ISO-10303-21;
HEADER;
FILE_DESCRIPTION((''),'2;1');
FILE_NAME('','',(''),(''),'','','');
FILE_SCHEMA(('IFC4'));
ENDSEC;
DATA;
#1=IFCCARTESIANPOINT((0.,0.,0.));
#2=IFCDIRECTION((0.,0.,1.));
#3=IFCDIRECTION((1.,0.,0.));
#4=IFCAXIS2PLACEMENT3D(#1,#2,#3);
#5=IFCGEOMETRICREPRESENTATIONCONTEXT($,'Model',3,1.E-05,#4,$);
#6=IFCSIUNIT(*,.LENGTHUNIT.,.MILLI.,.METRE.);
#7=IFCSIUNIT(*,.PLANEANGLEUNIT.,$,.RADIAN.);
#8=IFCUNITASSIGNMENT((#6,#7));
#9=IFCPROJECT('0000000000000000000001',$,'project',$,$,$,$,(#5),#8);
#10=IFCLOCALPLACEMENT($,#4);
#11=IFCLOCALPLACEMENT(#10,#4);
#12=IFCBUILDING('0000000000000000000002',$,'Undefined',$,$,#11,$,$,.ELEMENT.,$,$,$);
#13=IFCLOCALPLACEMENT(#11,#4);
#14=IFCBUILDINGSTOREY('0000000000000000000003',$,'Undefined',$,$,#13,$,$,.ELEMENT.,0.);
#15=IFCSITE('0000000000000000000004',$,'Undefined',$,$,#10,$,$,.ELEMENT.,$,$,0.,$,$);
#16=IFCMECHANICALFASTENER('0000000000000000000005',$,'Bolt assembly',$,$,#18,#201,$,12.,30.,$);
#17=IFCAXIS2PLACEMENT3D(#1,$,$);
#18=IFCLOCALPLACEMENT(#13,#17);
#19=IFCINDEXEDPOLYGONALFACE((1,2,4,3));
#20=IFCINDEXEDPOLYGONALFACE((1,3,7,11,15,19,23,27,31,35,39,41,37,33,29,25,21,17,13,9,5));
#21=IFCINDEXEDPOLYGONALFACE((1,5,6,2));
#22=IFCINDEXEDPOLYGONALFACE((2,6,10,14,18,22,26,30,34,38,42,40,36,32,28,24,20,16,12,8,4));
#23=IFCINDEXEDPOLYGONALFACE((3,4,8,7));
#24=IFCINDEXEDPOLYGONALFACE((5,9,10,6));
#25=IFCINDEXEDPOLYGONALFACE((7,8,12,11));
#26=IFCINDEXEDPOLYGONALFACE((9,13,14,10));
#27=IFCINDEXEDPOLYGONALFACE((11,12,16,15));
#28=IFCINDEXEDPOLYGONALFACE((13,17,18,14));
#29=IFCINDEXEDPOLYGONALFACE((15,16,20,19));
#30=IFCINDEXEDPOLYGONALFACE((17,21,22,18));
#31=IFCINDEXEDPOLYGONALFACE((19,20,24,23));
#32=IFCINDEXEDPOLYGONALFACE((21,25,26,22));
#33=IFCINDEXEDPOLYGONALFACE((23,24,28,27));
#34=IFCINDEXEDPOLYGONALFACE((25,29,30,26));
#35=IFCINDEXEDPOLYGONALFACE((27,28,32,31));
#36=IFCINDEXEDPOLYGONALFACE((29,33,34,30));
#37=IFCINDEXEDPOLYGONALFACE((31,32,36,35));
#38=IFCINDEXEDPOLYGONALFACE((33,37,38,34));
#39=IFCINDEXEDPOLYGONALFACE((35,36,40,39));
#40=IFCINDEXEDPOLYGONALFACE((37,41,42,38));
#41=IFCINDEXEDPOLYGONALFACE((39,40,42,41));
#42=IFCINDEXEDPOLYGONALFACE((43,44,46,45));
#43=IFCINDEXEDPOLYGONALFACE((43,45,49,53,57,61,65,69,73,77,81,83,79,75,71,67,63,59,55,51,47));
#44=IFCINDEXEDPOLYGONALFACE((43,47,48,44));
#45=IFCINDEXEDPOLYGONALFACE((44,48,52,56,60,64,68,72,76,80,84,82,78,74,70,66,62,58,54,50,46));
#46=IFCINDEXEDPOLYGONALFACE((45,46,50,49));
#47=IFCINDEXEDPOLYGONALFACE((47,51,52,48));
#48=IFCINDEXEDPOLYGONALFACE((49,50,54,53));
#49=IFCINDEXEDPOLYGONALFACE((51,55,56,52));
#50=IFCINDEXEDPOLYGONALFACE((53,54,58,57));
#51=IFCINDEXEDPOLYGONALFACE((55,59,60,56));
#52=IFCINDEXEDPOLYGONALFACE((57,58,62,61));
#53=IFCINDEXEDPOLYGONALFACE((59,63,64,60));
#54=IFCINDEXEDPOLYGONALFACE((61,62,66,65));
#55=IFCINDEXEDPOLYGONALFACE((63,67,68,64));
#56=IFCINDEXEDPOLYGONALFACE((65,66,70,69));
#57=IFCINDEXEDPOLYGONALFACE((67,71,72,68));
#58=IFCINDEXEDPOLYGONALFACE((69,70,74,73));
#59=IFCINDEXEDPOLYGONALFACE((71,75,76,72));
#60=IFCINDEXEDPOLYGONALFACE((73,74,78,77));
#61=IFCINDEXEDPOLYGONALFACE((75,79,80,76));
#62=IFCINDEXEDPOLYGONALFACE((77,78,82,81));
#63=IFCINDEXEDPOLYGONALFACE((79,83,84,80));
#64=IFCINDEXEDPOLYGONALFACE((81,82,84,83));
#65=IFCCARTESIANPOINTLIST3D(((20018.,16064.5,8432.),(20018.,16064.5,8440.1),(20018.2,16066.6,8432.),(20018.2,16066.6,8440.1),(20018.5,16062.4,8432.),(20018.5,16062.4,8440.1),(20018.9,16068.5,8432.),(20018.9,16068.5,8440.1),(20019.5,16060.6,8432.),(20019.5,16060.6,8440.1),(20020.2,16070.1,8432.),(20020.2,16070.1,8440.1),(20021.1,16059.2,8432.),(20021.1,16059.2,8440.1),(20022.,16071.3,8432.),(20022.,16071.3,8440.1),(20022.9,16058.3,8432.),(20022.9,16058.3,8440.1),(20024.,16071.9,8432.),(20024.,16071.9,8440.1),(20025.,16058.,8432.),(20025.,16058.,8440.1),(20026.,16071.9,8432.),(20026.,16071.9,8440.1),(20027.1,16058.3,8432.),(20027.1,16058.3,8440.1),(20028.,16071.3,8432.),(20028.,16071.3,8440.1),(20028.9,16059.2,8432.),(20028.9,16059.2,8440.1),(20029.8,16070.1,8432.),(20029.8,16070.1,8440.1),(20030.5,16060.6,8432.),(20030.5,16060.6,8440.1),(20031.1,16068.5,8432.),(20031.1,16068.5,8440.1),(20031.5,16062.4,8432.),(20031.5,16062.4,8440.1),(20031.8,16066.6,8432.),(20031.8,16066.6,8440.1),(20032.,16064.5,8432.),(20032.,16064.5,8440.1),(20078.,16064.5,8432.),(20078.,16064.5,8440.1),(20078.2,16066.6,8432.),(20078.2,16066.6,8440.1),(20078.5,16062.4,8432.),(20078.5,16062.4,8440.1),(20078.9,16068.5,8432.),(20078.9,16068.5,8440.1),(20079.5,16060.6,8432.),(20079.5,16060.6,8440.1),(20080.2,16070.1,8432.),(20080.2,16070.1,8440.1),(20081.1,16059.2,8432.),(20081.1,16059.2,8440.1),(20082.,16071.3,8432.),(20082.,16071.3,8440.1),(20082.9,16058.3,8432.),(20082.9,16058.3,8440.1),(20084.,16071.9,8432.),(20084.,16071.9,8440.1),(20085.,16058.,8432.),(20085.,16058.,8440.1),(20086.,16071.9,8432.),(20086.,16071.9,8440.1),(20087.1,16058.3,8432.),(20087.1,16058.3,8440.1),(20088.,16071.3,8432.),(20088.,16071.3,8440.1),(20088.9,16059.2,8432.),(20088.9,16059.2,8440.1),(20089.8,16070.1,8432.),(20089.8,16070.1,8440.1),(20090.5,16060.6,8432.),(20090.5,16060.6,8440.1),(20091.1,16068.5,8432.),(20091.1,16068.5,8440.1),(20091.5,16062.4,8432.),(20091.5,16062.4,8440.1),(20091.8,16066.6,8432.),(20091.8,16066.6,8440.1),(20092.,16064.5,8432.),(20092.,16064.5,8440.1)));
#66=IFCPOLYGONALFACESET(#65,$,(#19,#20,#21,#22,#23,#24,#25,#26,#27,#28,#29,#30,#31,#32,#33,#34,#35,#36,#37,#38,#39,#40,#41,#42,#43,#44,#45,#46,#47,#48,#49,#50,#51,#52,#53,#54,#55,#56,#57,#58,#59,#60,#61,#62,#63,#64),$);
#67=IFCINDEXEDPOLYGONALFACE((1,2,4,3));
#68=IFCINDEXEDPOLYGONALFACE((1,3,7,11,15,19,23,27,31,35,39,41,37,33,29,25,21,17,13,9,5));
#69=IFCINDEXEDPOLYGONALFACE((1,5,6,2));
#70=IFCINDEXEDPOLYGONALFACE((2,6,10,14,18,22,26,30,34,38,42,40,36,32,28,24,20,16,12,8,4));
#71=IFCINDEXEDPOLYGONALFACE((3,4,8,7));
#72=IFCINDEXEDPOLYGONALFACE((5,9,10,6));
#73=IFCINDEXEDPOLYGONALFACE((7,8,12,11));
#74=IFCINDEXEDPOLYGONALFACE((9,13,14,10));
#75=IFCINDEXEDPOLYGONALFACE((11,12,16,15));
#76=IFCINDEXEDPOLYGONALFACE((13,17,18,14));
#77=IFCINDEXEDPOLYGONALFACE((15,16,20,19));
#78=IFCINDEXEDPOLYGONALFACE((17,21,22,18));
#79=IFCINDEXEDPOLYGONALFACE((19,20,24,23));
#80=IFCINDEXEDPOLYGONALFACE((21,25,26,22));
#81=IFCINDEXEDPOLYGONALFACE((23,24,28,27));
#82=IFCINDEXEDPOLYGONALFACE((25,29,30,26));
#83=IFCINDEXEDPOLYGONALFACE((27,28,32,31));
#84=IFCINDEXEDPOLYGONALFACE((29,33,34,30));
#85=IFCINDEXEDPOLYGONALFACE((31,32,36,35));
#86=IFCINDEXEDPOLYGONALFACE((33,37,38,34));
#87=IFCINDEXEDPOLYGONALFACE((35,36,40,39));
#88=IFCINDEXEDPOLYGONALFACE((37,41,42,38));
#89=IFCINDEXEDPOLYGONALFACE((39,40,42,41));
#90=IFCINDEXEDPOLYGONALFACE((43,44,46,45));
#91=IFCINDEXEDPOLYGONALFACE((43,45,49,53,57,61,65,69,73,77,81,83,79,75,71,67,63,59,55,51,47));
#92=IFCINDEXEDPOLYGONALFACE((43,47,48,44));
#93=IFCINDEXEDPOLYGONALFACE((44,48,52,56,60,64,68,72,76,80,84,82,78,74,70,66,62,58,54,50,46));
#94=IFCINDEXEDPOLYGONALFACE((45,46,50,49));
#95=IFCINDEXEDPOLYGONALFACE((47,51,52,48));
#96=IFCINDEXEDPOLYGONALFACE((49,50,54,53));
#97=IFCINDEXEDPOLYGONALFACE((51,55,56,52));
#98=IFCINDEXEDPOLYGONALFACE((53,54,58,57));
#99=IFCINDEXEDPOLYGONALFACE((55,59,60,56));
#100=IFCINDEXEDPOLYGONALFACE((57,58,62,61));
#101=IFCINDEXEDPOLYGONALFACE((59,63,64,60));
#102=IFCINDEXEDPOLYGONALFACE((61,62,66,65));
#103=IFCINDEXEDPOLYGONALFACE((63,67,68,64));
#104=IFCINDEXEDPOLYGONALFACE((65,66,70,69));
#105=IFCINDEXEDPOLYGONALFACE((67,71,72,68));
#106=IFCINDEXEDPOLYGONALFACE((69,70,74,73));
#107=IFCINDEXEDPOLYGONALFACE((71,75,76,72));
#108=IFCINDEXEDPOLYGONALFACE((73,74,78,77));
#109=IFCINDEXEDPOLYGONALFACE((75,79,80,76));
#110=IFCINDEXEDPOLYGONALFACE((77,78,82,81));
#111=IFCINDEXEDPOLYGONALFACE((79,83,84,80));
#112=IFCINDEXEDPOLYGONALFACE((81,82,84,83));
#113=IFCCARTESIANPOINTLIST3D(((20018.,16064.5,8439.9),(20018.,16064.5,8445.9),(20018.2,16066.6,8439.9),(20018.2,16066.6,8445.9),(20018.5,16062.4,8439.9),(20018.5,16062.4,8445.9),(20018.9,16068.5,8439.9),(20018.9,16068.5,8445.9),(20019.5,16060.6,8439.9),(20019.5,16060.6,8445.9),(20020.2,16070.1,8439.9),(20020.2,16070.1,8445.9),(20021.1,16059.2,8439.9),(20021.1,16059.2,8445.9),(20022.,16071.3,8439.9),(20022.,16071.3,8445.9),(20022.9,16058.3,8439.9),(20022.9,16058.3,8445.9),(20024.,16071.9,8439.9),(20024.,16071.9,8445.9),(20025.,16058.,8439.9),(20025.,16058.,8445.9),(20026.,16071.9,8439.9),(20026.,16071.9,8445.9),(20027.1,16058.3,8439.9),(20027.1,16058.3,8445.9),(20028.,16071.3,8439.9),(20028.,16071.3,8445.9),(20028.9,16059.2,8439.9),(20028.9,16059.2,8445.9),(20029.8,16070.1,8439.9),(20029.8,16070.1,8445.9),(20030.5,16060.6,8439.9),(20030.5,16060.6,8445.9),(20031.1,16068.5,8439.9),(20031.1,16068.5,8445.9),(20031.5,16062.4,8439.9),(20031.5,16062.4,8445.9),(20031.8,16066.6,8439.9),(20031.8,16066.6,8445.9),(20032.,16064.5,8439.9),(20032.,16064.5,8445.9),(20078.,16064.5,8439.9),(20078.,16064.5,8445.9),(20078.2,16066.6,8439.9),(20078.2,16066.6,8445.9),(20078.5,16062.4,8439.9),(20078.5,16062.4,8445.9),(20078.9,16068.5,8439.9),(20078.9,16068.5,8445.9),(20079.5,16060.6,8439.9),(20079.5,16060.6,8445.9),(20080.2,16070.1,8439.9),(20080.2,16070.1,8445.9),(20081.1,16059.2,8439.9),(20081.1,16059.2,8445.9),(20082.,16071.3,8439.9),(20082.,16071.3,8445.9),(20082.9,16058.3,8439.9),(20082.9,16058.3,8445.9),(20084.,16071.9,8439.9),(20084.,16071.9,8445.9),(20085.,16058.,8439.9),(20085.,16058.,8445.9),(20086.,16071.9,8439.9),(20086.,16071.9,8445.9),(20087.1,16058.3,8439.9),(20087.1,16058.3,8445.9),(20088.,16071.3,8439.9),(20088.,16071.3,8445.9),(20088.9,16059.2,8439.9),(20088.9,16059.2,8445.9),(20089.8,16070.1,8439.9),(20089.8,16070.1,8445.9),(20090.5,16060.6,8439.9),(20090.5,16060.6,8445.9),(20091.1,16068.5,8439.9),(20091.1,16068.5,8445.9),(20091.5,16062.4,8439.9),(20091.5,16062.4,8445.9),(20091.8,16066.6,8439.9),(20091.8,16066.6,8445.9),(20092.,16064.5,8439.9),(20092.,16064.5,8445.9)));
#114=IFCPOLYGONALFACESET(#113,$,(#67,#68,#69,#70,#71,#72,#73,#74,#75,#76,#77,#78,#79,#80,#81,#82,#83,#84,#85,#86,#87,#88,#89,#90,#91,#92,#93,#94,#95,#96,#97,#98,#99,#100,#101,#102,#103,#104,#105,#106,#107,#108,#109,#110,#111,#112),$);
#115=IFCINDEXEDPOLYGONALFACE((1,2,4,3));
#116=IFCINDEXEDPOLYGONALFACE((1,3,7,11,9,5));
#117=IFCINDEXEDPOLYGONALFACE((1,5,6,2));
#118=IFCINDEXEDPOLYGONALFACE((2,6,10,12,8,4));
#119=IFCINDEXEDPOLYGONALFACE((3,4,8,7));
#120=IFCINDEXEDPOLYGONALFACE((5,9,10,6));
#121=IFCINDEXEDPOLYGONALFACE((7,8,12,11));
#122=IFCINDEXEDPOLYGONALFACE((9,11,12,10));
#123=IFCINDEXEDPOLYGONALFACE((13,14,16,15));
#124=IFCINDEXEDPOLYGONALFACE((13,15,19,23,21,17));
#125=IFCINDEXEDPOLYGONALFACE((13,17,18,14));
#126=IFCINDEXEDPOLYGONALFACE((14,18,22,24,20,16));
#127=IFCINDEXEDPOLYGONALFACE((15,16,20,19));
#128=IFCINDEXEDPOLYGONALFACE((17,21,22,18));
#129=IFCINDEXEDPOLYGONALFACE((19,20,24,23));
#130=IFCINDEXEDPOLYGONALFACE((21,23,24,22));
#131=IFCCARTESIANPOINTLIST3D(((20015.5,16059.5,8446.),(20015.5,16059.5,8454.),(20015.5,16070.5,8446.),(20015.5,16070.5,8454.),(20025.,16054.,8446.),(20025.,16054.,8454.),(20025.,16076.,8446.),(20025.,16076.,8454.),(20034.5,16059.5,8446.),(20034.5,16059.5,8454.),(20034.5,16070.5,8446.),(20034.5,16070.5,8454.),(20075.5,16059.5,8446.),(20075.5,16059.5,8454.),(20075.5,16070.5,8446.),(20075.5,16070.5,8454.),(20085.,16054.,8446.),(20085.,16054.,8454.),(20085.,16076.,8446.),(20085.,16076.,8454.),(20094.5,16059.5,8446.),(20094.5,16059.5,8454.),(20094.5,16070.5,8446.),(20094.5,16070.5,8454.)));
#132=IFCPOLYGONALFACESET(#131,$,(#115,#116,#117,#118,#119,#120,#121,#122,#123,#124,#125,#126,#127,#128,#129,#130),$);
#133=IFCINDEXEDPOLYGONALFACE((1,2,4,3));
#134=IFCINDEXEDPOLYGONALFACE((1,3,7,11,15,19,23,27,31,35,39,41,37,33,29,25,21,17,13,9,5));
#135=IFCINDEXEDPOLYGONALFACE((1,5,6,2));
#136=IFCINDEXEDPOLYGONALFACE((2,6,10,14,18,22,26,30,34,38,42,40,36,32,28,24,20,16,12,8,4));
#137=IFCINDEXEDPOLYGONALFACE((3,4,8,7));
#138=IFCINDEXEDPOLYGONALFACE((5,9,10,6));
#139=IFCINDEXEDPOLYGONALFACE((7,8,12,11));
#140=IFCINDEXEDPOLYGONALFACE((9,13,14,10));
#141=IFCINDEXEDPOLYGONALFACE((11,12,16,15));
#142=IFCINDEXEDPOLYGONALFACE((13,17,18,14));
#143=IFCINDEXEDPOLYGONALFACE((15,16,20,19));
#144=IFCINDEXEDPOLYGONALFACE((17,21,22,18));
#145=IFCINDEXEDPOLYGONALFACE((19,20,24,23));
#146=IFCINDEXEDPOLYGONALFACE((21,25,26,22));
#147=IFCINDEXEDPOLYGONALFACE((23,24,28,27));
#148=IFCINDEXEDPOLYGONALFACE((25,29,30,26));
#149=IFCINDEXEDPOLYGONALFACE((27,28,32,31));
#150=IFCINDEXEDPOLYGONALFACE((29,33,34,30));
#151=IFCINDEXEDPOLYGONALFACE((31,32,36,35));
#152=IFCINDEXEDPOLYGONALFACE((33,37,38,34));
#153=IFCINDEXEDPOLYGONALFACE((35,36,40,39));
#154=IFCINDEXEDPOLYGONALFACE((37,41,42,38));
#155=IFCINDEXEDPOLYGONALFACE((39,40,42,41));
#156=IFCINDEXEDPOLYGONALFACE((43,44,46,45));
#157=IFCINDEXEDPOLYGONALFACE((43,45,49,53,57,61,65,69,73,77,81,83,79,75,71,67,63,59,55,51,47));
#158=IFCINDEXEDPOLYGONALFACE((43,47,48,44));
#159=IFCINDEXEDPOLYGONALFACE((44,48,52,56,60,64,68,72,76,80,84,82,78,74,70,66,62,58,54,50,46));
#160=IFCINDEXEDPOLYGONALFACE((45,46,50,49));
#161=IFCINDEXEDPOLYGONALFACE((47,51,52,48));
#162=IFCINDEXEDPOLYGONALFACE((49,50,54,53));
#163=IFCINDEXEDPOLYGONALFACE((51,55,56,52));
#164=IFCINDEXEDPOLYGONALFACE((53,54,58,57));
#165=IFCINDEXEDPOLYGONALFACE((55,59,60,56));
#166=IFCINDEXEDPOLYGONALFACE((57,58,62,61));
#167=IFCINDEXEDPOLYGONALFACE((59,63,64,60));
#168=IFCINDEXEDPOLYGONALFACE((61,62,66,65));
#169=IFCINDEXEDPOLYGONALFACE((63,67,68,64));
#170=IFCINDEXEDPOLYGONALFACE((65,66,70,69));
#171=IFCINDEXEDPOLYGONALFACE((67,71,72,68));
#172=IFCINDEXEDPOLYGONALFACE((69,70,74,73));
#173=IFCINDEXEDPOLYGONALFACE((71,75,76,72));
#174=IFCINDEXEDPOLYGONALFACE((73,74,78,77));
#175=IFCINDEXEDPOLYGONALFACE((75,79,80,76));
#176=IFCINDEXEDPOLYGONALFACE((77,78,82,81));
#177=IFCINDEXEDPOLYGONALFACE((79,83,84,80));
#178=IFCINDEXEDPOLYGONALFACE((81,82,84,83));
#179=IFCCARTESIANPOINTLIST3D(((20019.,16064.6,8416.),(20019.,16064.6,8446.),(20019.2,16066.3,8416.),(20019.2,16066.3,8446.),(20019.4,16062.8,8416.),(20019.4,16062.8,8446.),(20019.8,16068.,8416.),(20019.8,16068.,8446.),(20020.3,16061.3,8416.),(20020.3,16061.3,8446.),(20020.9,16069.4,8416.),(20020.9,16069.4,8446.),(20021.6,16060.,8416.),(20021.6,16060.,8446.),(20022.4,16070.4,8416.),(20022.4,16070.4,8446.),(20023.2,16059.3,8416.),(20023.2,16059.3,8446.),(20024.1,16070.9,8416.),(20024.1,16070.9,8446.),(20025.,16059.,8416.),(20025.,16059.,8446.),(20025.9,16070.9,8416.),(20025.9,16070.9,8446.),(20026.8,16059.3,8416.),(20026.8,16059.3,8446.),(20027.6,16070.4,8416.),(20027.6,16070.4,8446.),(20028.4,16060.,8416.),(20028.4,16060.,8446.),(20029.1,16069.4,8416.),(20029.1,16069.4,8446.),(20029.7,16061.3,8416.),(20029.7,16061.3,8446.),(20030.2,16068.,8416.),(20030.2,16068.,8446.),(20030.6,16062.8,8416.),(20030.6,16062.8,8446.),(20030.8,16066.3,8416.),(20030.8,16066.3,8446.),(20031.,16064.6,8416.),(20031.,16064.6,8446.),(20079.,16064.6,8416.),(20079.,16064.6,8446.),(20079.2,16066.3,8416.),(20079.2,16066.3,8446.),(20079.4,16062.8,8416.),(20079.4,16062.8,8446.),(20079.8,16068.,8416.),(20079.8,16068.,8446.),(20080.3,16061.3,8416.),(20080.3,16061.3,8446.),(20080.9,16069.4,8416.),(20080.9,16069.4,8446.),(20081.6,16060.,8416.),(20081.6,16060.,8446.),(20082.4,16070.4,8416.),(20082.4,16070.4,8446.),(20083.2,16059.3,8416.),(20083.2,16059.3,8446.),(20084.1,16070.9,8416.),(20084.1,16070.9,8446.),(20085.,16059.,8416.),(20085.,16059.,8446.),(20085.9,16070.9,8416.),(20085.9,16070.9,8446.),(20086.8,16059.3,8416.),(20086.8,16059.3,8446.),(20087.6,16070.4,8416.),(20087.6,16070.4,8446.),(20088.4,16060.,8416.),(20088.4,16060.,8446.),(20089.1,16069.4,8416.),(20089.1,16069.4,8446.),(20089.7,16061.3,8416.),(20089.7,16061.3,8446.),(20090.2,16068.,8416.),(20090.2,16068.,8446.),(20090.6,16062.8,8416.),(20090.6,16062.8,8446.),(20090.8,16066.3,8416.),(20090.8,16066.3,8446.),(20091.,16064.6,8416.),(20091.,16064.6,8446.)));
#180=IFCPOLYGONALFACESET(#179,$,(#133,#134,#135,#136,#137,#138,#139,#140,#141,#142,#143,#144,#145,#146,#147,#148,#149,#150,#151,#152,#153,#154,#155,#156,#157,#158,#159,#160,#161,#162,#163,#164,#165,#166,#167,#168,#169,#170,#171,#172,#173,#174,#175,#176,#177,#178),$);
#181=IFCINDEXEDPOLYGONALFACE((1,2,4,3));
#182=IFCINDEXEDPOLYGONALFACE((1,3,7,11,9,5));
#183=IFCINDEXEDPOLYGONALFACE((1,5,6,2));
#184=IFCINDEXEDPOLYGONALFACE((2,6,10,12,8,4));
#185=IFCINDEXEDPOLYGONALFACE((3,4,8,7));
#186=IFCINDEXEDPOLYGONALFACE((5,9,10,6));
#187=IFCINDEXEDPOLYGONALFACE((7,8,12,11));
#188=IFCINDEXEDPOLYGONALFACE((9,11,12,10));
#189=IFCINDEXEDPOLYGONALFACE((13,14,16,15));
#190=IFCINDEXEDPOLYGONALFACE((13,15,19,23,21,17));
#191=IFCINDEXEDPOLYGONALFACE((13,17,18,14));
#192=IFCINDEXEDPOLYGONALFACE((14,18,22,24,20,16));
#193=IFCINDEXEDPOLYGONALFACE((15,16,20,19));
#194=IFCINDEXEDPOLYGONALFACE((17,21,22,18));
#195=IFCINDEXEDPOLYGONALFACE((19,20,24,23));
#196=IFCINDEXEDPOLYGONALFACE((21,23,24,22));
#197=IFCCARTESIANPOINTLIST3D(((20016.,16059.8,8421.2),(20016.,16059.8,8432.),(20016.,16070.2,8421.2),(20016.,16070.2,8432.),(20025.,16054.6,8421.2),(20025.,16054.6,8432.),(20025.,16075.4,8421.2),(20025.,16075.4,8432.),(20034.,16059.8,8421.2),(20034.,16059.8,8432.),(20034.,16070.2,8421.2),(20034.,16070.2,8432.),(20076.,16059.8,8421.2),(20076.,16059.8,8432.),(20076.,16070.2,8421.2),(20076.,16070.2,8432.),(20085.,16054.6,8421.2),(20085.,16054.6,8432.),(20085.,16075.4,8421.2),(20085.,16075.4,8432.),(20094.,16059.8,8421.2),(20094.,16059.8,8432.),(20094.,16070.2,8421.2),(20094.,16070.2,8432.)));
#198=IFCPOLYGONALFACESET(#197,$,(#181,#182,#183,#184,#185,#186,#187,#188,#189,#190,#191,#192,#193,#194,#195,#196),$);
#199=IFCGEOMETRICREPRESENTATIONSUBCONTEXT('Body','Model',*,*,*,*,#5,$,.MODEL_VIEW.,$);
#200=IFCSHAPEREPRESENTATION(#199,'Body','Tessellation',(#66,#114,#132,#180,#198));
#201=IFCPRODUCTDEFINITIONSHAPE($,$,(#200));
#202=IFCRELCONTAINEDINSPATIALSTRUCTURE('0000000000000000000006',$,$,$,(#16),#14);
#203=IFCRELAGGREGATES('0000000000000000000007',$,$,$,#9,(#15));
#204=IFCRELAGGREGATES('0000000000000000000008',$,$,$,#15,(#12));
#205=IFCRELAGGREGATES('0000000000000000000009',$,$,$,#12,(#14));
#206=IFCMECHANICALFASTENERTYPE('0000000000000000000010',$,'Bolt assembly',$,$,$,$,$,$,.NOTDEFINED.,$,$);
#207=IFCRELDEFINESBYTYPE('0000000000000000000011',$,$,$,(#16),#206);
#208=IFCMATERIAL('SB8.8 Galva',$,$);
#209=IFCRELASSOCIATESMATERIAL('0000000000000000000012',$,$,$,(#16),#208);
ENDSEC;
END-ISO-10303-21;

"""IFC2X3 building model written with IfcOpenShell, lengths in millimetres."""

from ifc_helpers import new_model, si_unit, frame, origin_with_axes, origin_2d_with_axis, place, context, subcontext, project, spatial, polyline, circle, outline, extrude, source, transform, mapped, material, type_object, element, save


model = new_model("IFC2X3")

# Units and contexts
model_context = context("Model", 3, precision=1e-05, world=origin_with_axes())
body_context = subcontext(model_context, "Body", "Model", "MODEL_VIEW")
ifc_project = project(units=[si_unit("LENGTHUNIT", "METRE", prefix="MILLI"), si_unit("PLANEANGLEUNIT", "RADIAN")], contexts=[model_context])

# Site, building, storey
site_placement = place(None, origin_with_axes())
site = spatial("IfcSite", under=ifc_project, at=site_placement, Name="Undefined", CompositionType="ELEMENT", RefElevation=0.0)
building_placement = place(site_placement, origin_with_axes())
building = spatial("IfcBuilding", under=site, at=building_placement, Name="Undefined", CompositionType="ELEMENT")
storey_placement = place(building_placement, origin_with_axes())
storey = spatial("IfcBuildingStorey", under=building, at=storey_placement, Name="Undefined", CompositionType="ELEMENT", Elevation=0.0)

# Mechanical fastener
mechanical_fastener_type = type_object("IfcMechanicalFastenerType", Name="Bolt assembly")
ifc_material_1 = material(Name="SB8.8 Galva")
shared_shape_1 = source(origin_with_axes(), body_context, "Body", "SweptSolid", [
    extrude(circle(Radius=7.0, at=origin_2d_with_axis()), frame((0.0, -0.1, 0.0), z_axis=(0.0, 1.0, 0.0), x_axis=(1.0, 0.0, 0.0)), (0.0, 0.0, 1.0), 8.1),
    extrude(circle(Radius=7.0, at=origin_2d_with_axis()), frame((0.0, -5.9, 0.0), z_axis=(0.0, 1.0, 0.0), x_axis=(1.0, 0.0, 0.0)), (0.0, 0.0, 1.0), 6.0),
    extrude(outline(polyline([(11.0, 0.0), (5.5, 9.5), (-5.5, 9.5), (-11.0, 0.0), (-5.5, -9.5), (5.5, -9.5), (11.0, 0.0)])), frame((0.0, -14.0, 0.0), z_axis=(0.0, 1.0, 0.0), x_axis=(1.0, 0.0, 0.0)), (0.0, 0.0, 1.0), 8.0),
    extrude(circle(Radius=6.0, at=origin_2d_with_axis()), frame((0.0, -6.0, 0.0), z_axis=(0.0, 1.0, 0.0), x_axis=(1.0, 0.0, 0.0)), (0.0, 0.0, 1.0), 30.0),
    extrude(outline(polyline([(10.4, 0.0), (5.2, 9.0), (-5.2, 9.0), (-10.4, 0.0), (-5.2, -9.0), (5.2, -9.0), (10.4, 0.0)])), frame((0.0, 8.0, 0.0), z_axis=(0.0, 1.0, 0.0), x_axis=(1.0, 0.0, 0.0)), (0.0, 0.0, 1.0), 10.8),
])
for number, where, z_axis, x_axis, name in (
    (1, (20055.0, 16065.0, 8440.0), (1.0, 0.0, 0.0), (0.0, -1.0, 0.0), "Bolt assembly"),
):
    element("IfcMechanicalFastener", number, at=place(storey_placement, frame(where, z_axis=z_axis, x_axis=x_axis)), inside=storey, type_object=mechanical_fastener_type, material=ifc_material_1, Name=name, NominalDiameter=12.0, NominalLength=30.0, context=body_context, shape_type="MappedRepresentation", body=[
        mapped(shared_shape_1, transform((0.0, 0.0, -30.0))),
        mapped(shared_shape_1, transform((0.0, 0.0, 30.0))),
    ])

save(model, "model.ifc")
